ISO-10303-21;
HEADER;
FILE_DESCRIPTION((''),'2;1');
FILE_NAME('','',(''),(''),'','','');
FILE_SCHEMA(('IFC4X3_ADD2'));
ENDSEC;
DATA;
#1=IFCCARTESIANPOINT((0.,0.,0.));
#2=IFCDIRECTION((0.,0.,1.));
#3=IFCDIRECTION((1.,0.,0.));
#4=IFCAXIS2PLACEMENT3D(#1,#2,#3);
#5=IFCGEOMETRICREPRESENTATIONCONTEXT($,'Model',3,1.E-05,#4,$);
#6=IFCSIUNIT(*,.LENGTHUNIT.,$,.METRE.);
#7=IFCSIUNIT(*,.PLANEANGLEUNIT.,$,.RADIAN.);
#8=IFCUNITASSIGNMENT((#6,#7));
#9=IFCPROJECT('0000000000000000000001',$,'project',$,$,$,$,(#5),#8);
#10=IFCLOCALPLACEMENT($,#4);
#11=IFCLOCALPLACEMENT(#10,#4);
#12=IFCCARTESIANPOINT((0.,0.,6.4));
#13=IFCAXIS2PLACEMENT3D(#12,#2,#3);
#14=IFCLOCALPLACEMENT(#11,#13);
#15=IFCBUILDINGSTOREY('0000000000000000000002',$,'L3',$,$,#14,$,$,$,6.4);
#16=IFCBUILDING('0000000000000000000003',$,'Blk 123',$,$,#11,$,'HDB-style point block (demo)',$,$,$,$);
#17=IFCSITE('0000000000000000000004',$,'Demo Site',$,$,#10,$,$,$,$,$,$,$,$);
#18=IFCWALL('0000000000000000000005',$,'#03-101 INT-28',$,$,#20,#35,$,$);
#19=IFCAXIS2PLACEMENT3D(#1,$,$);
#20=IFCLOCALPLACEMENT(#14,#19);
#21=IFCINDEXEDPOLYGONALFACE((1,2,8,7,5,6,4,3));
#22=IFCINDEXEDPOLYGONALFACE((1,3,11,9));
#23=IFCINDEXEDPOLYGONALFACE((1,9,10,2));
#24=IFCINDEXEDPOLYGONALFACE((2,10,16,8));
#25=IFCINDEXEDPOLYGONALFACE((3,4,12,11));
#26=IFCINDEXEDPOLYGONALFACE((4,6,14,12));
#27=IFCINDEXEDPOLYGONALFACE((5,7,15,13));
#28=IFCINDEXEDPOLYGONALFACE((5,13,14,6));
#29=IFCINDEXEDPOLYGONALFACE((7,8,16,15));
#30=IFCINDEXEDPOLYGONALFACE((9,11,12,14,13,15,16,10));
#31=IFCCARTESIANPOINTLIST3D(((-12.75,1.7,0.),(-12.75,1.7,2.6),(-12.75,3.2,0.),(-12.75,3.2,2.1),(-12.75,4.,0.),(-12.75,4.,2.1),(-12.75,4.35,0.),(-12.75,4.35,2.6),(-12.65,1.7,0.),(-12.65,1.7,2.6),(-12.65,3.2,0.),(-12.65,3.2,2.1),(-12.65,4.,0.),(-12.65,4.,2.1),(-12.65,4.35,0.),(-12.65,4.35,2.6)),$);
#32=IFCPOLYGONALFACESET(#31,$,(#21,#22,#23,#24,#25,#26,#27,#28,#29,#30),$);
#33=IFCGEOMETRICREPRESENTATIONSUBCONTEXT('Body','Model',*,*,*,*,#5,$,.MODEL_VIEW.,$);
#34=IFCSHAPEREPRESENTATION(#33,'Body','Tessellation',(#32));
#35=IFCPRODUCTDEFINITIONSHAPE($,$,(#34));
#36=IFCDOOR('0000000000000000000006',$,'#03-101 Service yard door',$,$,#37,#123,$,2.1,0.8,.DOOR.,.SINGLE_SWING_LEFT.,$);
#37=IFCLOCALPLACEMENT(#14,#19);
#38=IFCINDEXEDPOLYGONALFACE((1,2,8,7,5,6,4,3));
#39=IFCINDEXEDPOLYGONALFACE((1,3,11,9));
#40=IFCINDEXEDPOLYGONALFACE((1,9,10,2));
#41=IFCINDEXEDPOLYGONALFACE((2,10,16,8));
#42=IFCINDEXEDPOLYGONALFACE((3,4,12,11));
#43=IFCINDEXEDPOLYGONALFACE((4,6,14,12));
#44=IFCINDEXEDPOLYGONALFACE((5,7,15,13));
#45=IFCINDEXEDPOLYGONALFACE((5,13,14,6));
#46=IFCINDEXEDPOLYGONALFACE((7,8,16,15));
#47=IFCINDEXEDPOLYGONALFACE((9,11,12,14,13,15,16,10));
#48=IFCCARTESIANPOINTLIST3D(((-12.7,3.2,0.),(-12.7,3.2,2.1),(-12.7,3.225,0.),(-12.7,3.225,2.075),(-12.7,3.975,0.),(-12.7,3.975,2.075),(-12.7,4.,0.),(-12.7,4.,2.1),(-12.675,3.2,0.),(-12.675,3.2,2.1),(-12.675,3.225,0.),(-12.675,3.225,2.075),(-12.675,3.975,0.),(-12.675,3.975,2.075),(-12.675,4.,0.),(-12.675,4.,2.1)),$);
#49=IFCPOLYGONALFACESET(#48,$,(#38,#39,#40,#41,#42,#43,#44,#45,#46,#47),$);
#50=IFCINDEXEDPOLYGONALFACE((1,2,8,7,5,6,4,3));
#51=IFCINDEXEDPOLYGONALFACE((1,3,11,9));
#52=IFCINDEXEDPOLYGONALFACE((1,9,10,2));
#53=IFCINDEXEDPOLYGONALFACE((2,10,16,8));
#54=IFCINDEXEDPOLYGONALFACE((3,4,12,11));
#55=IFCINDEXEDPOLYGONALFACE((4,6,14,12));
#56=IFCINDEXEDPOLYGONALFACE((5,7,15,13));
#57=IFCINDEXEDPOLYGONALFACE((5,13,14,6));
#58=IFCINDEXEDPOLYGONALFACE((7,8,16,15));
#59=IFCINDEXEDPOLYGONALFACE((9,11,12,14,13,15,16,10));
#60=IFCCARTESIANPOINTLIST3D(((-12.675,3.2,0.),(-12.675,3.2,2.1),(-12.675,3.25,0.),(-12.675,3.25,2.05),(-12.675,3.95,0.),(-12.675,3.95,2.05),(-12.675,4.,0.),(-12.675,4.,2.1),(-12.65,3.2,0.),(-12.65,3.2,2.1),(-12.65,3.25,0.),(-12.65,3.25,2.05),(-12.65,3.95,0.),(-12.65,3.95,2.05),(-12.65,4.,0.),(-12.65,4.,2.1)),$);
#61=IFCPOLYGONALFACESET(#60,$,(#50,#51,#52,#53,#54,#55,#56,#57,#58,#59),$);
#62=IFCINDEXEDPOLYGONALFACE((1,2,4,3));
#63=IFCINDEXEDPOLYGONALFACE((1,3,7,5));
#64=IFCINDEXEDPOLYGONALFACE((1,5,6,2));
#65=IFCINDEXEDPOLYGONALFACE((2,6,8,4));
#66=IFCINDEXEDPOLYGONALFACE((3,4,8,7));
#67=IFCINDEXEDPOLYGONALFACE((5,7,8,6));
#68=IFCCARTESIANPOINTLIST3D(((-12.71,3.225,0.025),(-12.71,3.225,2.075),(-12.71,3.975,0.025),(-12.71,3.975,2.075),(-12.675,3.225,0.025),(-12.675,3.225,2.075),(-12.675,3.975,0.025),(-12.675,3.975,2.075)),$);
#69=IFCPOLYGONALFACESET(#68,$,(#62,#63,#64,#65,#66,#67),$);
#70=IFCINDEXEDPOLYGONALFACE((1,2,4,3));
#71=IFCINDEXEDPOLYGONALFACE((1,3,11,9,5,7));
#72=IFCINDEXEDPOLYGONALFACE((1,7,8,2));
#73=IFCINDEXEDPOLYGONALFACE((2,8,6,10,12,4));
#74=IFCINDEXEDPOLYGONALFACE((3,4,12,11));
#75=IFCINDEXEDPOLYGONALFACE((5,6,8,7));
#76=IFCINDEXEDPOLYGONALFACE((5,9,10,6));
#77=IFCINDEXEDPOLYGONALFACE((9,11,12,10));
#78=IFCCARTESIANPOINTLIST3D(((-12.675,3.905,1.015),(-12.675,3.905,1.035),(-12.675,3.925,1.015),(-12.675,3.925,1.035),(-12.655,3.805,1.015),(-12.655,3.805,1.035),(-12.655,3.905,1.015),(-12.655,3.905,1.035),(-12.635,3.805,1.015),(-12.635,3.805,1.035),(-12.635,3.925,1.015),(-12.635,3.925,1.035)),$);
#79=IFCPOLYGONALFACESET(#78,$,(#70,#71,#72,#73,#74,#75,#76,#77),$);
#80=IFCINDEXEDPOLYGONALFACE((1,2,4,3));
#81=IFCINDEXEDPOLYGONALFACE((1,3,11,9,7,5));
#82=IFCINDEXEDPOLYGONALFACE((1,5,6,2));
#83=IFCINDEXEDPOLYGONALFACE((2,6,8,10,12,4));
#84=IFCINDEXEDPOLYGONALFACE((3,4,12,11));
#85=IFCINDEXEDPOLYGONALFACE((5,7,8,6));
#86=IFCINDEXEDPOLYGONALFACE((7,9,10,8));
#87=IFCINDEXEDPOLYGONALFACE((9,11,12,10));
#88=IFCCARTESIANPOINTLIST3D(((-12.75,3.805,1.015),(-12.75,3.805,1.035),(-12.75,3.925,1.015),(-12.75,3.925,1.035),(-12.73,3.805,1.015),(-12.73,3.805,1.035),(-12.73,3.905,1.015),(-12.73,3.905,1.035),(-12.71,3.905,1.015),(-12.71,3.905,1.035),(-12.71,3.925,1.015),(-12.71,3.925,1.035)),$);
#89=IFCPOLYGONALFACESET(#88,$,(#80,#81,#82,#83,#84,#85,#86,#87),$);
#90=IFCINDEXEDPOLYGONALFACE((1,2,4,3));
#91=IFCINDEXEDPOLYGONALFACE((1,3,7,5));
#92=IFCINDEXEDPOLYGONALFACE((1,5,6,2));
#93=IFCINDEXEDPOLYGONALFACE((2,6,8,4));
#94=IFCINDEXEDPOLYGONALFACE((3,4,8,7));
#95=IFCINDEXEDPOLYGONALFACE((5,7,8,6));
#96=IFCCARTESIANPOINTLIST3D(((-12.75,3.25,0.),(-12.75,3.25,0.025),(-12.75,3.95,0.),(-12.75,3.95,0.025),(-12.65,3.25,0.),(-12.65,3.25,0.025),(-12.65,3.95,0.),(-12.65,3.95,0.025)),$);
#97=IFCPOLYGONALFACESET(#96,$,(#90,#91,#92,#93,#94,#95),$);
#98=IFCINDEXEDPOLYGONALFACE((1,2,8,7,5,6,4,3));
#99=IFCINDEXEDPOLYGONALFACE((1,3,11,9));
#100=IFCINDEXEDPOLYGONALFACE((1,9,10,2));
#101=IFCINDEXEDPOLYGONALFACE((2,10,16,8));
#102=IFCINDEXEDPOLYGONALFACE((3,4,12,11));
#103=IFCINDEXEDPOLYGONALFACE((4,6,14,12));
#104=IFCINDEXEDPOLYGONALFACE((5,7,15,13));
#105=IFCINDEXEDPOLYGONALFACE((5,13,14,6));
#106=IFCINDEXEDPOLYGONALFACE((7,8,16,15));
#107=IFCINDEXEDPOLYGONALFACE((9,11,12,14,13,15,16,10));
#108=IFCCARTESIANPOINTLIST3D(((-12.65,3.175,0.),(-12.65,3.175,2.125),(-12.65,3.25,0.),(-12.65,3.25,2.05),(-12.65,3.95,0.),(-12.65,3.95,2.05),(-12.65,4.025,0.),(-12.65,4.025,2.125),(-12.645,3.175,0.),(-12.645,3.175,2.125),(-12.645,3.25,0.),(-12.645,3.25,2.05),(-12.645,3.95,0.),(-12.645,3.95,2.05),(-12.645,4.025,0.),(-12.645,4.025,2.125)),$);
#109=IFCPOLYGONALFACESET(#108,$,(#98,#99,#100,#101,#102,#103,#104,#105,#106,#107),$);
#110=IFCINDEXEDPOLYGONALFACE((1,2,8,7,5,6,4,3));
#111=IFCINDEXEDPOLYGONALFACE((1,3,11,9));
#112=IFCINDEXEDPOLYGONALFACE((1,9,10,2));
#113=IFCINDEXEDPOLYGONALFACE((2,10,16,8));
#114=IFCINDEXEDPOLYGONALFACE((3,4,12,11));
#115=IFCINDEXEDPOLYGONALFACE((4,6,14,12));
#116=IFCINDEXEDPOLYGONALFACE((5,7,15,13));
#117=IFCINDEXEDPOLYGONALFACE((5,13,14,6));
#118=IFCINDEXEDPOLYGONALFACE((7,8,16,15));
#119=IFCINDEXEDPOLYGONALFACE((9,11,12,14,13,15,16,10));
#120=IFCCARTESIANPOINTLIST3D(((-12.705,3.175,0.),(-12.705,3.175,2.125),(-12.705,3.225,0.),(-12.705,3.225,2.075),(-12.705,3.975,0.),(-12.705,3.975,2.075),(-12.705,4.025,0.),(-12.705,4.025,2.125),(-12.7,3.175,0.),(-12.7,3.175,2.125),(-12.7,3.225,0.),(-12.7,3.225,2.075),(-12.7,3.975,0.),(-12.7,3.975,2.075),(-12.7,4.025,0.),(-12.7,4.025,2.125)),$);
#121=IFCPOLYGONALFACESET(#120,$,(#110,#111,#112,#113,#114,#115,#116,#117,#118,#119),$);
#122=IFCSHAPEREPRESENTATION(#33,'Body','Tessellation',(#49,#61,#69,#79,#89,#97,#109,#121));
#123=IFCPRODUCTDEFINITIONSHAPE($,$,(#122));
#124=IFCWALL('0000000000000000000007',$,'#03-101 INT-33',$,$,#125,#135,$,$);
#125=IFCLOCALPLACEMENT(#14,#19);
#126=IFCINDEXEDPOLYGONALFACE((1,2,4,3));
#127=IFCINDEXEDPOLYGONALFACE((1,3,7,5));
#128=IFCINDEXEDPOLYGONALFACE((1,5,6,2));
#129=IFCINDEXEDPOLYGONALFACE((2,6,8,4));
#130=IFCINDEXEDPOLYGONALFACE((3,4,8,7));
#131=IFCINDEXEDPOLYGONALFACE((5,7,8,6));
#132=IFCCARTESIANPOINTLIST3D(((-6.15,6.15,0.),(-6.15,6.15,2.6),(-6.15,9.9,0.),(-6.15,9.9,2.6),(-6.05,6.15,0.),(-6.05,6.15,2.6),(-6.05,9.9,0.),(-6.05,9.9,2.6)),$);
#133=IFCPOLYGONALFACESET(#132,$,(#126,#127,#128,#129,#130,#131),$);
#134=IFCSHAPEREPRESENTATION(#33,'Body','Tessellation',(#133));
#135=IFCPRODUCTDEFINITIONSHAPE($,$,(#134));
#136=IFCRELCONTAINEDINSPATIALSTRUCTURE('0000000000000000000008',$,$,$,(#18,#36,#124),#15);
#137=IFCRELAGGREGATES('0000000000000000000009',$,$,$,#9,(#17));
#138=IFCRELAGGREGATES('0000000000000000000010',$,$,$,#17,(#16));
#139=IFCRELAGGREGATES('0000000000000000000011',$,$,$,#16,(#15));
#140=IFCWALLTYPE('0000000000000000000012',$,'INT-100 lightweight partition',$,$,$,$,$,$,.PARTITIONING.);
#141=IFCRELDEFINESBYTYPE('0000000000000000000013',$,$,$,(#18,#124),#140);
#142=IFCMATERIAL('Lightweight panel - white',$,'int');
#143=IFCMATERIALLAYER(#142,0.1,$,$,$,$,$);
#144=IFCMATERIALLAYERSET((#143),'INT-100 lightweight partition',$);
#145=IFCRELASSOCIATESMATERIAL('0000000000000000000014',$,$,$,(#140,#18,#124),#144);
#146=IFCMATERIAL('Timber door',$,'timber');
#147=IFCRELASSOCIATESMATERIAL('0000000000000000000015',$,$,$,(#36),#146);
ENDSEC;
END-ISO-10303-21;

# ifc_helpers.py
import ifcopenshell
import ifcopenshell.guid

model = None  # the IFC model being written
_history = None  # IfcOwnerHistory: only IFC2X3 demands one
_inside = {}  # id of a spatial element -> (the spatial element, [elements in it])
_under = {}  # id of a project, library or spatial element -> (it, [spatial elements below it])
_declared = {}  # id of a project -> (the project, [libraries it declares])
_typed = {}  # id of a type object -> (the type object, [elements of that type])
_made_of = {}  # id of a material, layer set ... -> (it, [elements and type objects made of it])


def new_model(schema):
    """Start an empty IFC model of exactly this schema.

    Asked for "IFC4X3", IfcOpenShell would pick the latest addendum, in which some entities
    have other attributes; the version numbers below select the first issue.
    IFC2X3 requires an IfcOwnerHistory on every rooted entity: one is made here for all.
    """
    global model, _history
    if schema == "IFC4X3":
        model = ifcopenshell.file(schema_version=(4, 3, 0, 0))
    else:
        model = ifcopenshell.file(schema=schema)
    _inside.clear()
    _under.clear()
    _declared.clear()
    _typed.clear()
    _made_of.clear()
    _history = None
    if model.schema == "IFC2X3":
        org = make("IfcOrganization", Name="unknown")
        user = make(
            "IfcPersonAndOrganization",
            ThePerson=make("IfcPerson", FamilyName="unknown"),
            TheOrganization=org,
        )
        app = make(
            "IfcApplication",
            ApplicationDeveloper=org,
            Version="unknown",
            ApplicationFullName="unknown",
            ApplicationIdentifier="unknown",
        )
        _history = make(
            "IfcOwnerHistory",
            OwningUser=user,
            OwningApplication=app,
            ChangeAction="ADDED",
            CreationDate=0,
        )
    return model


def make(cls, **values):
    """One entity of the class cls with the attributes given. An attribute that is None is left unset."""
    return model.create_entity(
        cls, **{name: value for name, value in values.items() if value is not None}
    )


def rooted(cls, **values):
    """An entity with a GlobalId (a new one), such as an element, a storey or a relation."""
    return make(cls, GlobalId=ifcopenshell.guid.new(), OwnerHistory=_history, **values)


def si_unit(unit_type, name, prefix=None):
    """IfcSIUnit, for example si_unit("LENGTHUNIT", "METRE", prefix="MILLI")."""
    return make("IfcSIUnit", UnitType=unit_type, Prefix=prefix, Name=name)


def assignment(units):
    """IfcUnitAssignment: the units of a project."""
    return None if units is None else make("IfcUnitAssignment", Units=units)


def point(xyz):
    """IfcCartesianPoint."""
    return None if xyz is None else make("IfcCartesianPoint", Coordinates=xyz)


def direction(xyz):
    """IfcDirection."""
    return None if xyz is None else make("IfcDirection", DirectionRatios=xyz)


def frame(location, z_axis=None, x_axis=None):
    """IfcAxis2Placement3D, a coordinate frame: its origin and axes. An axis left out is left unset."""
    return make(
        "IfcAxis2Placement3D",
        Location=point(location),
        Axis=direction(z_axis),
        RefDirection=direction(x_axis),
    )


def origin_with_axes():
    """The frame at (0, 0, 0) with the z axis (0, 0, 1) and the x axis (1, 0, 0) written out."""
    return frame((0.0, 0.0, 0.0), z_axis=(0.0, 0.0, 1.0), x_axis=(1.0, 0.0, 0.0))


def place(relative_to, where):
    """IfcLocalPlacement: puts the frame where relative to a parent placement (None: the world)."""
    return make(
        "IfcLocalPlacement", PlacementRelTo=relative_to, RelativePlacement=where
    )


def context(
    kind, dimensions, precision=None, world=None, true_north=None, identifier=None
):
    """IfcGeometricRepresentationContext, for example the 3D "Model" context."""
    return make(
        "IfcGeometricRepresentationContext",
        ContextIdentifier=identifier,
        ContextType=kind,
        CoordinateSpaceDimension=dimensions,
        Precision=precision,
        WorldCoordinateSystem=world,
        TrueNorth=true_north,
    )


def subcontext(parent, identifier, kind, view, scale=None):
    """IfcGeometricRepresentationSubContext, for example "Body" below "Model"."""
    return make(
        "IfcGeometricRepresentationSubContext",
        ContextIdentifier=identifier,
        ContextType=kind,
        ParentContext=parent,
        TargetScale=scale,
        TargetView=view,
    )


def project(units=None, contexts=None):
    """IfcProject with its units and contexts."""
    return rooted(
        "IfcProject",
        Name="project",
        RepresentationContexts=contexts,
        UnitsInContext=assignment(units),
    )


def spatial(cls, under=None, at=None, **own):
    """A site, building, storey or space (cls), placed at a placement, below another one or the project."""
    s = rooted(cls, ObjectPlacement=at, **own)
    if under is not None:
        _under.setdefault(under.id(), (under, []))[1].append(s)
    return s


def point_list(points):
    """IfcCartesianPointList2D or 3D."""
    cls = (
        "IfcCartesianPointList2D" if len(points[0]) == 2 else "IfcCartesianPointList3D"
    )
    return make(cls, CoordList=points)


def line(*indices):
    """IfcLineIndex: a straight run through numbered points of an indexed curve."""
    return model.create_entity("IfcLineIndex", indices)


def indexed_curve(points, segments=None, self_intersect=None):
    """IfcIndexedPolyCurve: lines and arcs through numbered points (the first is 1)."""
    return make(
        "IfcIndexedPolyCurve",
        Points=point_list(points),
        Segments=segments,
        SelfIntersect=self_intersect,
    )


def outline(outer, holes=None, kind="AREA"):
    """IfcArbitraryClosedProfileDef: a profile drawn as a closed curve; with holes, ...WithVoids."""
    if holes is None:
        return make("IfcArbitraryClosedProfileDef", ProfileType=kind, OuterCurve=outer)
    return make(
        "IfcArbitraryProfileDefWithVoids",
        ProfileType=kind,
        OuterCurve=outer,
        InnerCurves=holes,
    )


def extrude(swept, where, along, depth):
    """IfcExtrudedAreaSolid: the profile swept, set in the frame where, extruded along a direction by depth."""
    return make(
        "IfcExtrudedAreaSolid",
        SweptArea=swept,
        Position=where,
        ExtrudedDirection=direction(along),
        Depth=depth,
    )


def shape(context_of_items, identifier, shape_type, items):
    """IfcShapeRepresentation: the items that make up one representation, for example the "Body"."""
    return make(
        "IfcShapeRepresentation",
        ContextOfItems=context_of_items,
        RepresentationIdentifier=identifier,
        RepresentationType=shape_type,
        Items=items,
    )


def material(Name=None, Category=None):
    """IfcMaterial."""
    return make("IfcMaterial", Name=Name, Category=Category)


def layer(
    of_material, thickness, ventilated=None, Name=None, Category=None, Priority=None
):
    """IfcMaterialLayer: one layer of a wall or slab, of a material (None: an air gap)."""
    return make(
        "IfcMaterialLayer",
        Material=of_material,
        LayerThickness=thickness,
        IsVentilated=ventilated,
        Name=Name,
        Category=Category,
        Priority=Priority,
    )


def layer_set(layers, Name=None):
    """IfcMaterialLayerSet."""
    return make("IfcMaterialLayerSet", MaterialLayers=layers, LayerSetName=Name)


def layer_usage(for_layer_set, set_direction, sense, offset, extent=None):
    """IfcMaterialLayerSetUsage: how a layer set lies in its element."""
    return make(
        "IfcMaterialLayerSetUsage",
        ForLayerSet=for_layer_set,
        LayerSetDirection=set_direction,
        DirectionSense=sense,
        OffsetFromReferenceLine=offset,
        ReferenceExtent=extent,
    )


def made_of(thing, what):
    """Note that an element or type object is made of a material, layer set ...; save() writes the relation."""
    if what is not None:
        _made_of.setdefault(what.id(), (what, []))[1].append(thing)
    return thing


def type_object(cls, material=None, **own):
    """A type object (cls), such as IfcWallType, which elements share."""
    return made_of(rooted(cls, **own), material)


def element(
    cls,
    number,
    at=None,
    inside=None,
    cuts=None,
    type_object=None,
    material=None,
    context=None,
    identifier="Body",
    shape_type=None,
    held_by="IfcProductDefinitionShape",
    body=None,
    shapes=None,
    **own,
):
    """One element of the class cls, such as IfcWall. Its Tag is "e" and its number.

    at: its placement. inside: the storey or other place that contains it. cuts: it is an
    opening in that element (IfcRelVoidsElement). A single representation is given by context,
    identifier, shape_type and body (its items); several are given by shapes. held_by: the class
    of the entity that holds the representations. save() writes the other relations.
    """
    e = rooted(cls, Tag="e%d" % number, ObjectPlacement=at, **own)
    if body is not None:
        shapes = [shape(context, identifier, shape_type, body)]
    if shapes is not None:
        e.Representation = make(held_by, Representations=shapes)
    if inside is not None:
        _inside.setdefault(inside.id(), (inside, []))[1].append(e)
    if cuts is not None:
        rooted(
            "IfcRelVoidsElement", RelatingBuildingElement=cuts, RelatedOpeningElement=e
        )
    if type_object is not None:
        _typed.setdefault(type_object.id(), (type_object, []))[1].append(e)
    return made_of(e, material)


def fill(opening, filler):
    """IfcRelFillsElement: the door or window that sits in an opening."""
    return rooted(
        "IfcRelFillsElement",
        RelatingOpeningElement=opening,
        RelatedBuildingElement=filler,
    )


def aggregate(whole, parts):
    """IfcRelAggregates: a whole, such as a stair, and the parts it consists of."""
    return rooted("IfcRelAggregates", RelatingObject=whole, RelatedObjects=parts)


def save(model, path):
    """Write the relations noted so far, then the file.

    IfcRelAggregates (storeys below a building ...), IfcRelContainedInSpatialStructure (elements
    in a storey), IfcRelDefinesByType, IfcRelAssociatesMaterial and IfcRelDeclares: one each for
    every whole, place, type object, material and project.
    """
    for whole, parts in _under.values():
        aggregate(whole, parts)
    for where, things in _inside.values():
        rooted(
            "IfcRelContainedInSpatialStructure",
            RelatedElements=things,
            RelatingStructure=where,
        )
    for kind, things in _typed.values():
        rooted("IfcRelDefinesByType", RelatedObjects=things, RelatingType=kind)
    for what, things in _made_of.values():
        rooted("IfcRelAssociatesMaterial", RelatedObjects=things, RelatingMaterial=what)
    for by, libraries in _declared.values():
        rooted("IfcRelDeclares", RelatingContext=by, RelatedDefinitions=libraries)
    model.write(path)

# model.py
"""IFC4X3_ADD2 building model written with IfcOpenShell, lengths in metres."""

from ifc_helpers import new_model, si_unit, frame, origin_with_axes, place, context, subcontext, project, spatial, line, indexed_curve, outline, extrude, material, layer, layer_set, layer_usage, type_object, element, fill, save


model = new_model("IFC4X3_ADD2")

# Units and contexts
model_context = context("Model", 3, precision=1e-05, world=origin_with_axes())
body_context = subcontext(model_context, "Body", "Model", "MODEL_VIEW")
ifc_project = project(units=[si_unit("LENGTHUNIT", "METRE"), si_unit("PLANEANGLEUNIT", "RADIAN")], contexts=[model_context])

# Site, building, storey
site_placement = place(None, origin_with_axes())
site = spatial("IfcSite", under=ifc_project, at=site_placement, Name="Demo Site")
building_placement = place(site_placement, origin_with_axes())
building = spatial("IfcBuilding", under=site, at=building_placement, Name="Blk 123", LongName="HDB-style point block (demo)")
storey_placement = place(building_placement, frame((0.0, 0.0, 6.4), z_axis=(0.0, 0.0, 1.0), x_axis=(1.0, 0.0, 0.0)))
storey = spatial("IfcBuildingStorey", under=building, at=storey_placement, Name="L3", Elevation=6.4)

# Shared definitions
ifc_material_1 = material(Name="Timber door", Category="timber")

# Shared definitions
ifc_material_2 = material(Name="Lightweight panel - white", Category="int")
ifc_layer_1 = layer(ifc_material_2, 0.1)
ifc_layer_set_1 = layer_set([ifc_layer_1], Name="INT-100 lightweight partition")
ifc_layer_usage_1 = layer_usage(ifc_layer_set_1, "AXIS2", "POSITIVE", -0.05)
wall_type_1 = type_object("IfcWallType", Name="INT-100 lightweight partition", PredefinedType="PARTITIONING", material=ifc_layer_set_1)

# Wall, opening, door
wall_1_placement = place(storey_placement, frame((-12.7, 1.7, 0.0), z_axis=(0.0, 0.0, 1.0), x_axis=(0.0, 1.0, 0.0)))
wall_1 = element("IfcWall", 1, at=wall_1_placement, inside=storey, type_object=wall_type_1, material=ifc_layer_usage_1, Name="#03-101 INT-28", context=body_context, shape_type="SweptSolid", body=[
    extrude(outline(indexed_curve([(0.0, 0.0), (0.0, 0.1), (2.65, 0.1), (2.65, 0.0), (0.0, 0.0)], self_intersect=False)), frame((0.0, -0.05, 0.0), z_axis=(0.0, 0.0, 1.0), x_axis=(1.0, 0.0, 0.0)), (0.0, 0.0, 1.0), 2.6),
])
opening_1_placement = place(wall_1_placement, frame((1.5, -0.15, 0.0), z_axis=(0.0, 0.0, 1.0), x_axis=(1.0, 0.0, 0.0)))
opening_1 = element("IfcOpeningElement", 2, at=opening_1_placement, cuts=wall_1, context=body_context, shape_type="SweptSolid", body=[
    extrude(outline(indexed_curve([(0.0, 0.0), (0.0, 0.3), (0.8, 0.3), (0.8, 0.0), (0.0, 0.0)], self_intersect=False)), origin_with_axes(), (0.0, 0.0, 1.0), 2.1),
])
door_1_placement = place(opening_1_placement, frame((0.0, 0.1, 0.0), z_axis=(0.0, 0.0, 1.0), x_axis=(1.0, 0.0, 0.0)))
door_1 = element("IfcDoor", 3, at=door_1_placement, inside=storey, material=ifc_material_1, Name="#03-101 Service yard door", OperationType="SINGLE_SWING_LEFT", OverallHeight=2.1, OverallWidth=0.8, PredefinedType="DOOR", context=body_context, shape_type="SweptSolid", body=[
    extrude(outline(indexed_curve([(0.0, 0.0), (0.0, 2.1), (0.8, 2.1), (0.8, 0.0), (0.775, 0.0), (0.775, 2.075), (0.025, 2.075), (0.025, 0.0)], segments=[line(1, 2, 3, 4, 5, 6, 7, 8, 1)])), frame((0.0, 0.025, 0.0), z_axis=(0.0, -1.0, 0.0), x_axis=(1.0, 0.0, 0.0)), (0.0, 0.0, -1.0), 0.025),
    extrude(outline(indexed_curve([(0.0, 0.0), (0.0, 2.1), (0.8, 2.1), (0.8, 0.0), (0.75, 0.0), (0.75, 2.05), (0.05, 2.05), (0.05, 0.0)], segments=[line(1, 2, 3, 4, 5, 6, 7, 8, 1)])), frame((0.0, 0.0, 0.0), z_axis=(0.0, -1.0, 0.0), x_axis=(1.0, 0.0, 0.0)), (0.0, 0.0, -1.0), 0.025),
    extrude(outline(indexed_curve([(0.0, 0.0), (0.75, 0.0), (0.75, 0.035), (0.0, 0.035)], segments=[line(1, 2, 3, 4, 1)])), frame((0.025, 0.025, 0.025), z_axis=(0.0, 0.0, 1.0), x_axis=(1.0, 0.0, 0.0)), (0.0, 0.0, 1.0), 2.05),
    extrude(outline(indexed_curve([(0.0, 0.0), (0.0, -0.04), (-0.12, -0.04), (-0.12, -0.02), (-0.02, -0.02), (-0.02, 0.0)], segments=[line(1, 2, 3, 4, 5, 6, 1)])), frame((0.725, 0.025, 1.015), z_axis=(0.0, 0.0, 1.0), x_axis=(1.0, 0.0, 0.0)), (0.0, 0.0, 1.0), 0.02),
    extrude(outline(indexed_curve([(0.0, 0.0), (0.0, 0.04), (-0.12, 0.04), (-0.12, 0.02), (-0.02, 0.02), (-0.02, 0.0)], segments=[line(1, 2, 3, 4, 5, 6, 1)])), frame((0.725, 0.06, 1.015), z_axis=(0.0, 0.0, 1.0), x_axis=(1.0, 0.0, 0.0)), (0.0, 0.0, 1.0), 0.02),
    extrude(outline(indexed_curve([(0.0, 0.0), (0.7, 0.0), (0.7, 0.1), (0.0, 0.1)], segments=[line(1, 2, 3, 4, 1)])), frame((0.05, 0.0, 0.0), z_axis=(0.0, 0.0, 1.0), x_axis=(1.0, 0.0, 0.0)), (0.0, 0.0, 1.0), 0.025),
    extrude(outline(indexed_curve([(0.0, 0.0), (0.0, 2.125), (0.85, 2.125), (0.85, 0.0), (0.775, 0.0), (0.775, 2.05), (0.075, 2.05), (0.075, 0.0)], segments=[line(1, 2, 3, 4, 5, 6, 7, 8, 1)])), frame((-0.025, -0.005, 0.0), z_axis=(0.0, -1.0, 0.0), x_axis=(1.0, 0.0, 0.0)), (0.0, 0.0, -1.0), 0.005),
    extrude(outline(indexed_curve([(0.0, 0.0), (0.0, 2.125), (0.85, 2.125), (0.85, 0.0), (0.8, 0.0), (0.8, 2.075), (0.05, 2.075), (0.05, 0.0)], segments=[line(1, 2, 3, 4, 5, 6, 7, 8, 1)])), frame((-0.025, 0.05, 0.0), z_axis=(0.0, -1.0, 0.0), x_axis=(1.0, 0.0, 0.0)), (0.0, 0.0, -1.0), 0.005),
])
fill(opening_1, door_1)

# Wall
wall_2_placement = place(storey_placement, frame((-6.1, 6.15, 0.0), z_axis=(0.0, 0.0, 1.0), x_axis=(0.0, 1.0, 0.0)))
element("IfcWall", 4, at=wall_2_placement, inside=storey, type_object=wall_type_1, material=ifc_layer_usage_1, Name="#03-101 INT-33", context=body_context, shape_type="SweptSolid", body=[
    extrude(outline(indexed_curve([(0.0, 0.0), (0.0, 0.1), (3.75, 0.1), (3.75, 0.0), (0.0, 0.0)], self_intersect=False)), frame((0.0, -0.05, 0.0), z_axis=(0.0, 0.0, 1.0), x_axis=(1.0, 0.0, 0.0)), (0.0, 0.0, 1.0), 2.6),
])

save(model, "model.ifc")
